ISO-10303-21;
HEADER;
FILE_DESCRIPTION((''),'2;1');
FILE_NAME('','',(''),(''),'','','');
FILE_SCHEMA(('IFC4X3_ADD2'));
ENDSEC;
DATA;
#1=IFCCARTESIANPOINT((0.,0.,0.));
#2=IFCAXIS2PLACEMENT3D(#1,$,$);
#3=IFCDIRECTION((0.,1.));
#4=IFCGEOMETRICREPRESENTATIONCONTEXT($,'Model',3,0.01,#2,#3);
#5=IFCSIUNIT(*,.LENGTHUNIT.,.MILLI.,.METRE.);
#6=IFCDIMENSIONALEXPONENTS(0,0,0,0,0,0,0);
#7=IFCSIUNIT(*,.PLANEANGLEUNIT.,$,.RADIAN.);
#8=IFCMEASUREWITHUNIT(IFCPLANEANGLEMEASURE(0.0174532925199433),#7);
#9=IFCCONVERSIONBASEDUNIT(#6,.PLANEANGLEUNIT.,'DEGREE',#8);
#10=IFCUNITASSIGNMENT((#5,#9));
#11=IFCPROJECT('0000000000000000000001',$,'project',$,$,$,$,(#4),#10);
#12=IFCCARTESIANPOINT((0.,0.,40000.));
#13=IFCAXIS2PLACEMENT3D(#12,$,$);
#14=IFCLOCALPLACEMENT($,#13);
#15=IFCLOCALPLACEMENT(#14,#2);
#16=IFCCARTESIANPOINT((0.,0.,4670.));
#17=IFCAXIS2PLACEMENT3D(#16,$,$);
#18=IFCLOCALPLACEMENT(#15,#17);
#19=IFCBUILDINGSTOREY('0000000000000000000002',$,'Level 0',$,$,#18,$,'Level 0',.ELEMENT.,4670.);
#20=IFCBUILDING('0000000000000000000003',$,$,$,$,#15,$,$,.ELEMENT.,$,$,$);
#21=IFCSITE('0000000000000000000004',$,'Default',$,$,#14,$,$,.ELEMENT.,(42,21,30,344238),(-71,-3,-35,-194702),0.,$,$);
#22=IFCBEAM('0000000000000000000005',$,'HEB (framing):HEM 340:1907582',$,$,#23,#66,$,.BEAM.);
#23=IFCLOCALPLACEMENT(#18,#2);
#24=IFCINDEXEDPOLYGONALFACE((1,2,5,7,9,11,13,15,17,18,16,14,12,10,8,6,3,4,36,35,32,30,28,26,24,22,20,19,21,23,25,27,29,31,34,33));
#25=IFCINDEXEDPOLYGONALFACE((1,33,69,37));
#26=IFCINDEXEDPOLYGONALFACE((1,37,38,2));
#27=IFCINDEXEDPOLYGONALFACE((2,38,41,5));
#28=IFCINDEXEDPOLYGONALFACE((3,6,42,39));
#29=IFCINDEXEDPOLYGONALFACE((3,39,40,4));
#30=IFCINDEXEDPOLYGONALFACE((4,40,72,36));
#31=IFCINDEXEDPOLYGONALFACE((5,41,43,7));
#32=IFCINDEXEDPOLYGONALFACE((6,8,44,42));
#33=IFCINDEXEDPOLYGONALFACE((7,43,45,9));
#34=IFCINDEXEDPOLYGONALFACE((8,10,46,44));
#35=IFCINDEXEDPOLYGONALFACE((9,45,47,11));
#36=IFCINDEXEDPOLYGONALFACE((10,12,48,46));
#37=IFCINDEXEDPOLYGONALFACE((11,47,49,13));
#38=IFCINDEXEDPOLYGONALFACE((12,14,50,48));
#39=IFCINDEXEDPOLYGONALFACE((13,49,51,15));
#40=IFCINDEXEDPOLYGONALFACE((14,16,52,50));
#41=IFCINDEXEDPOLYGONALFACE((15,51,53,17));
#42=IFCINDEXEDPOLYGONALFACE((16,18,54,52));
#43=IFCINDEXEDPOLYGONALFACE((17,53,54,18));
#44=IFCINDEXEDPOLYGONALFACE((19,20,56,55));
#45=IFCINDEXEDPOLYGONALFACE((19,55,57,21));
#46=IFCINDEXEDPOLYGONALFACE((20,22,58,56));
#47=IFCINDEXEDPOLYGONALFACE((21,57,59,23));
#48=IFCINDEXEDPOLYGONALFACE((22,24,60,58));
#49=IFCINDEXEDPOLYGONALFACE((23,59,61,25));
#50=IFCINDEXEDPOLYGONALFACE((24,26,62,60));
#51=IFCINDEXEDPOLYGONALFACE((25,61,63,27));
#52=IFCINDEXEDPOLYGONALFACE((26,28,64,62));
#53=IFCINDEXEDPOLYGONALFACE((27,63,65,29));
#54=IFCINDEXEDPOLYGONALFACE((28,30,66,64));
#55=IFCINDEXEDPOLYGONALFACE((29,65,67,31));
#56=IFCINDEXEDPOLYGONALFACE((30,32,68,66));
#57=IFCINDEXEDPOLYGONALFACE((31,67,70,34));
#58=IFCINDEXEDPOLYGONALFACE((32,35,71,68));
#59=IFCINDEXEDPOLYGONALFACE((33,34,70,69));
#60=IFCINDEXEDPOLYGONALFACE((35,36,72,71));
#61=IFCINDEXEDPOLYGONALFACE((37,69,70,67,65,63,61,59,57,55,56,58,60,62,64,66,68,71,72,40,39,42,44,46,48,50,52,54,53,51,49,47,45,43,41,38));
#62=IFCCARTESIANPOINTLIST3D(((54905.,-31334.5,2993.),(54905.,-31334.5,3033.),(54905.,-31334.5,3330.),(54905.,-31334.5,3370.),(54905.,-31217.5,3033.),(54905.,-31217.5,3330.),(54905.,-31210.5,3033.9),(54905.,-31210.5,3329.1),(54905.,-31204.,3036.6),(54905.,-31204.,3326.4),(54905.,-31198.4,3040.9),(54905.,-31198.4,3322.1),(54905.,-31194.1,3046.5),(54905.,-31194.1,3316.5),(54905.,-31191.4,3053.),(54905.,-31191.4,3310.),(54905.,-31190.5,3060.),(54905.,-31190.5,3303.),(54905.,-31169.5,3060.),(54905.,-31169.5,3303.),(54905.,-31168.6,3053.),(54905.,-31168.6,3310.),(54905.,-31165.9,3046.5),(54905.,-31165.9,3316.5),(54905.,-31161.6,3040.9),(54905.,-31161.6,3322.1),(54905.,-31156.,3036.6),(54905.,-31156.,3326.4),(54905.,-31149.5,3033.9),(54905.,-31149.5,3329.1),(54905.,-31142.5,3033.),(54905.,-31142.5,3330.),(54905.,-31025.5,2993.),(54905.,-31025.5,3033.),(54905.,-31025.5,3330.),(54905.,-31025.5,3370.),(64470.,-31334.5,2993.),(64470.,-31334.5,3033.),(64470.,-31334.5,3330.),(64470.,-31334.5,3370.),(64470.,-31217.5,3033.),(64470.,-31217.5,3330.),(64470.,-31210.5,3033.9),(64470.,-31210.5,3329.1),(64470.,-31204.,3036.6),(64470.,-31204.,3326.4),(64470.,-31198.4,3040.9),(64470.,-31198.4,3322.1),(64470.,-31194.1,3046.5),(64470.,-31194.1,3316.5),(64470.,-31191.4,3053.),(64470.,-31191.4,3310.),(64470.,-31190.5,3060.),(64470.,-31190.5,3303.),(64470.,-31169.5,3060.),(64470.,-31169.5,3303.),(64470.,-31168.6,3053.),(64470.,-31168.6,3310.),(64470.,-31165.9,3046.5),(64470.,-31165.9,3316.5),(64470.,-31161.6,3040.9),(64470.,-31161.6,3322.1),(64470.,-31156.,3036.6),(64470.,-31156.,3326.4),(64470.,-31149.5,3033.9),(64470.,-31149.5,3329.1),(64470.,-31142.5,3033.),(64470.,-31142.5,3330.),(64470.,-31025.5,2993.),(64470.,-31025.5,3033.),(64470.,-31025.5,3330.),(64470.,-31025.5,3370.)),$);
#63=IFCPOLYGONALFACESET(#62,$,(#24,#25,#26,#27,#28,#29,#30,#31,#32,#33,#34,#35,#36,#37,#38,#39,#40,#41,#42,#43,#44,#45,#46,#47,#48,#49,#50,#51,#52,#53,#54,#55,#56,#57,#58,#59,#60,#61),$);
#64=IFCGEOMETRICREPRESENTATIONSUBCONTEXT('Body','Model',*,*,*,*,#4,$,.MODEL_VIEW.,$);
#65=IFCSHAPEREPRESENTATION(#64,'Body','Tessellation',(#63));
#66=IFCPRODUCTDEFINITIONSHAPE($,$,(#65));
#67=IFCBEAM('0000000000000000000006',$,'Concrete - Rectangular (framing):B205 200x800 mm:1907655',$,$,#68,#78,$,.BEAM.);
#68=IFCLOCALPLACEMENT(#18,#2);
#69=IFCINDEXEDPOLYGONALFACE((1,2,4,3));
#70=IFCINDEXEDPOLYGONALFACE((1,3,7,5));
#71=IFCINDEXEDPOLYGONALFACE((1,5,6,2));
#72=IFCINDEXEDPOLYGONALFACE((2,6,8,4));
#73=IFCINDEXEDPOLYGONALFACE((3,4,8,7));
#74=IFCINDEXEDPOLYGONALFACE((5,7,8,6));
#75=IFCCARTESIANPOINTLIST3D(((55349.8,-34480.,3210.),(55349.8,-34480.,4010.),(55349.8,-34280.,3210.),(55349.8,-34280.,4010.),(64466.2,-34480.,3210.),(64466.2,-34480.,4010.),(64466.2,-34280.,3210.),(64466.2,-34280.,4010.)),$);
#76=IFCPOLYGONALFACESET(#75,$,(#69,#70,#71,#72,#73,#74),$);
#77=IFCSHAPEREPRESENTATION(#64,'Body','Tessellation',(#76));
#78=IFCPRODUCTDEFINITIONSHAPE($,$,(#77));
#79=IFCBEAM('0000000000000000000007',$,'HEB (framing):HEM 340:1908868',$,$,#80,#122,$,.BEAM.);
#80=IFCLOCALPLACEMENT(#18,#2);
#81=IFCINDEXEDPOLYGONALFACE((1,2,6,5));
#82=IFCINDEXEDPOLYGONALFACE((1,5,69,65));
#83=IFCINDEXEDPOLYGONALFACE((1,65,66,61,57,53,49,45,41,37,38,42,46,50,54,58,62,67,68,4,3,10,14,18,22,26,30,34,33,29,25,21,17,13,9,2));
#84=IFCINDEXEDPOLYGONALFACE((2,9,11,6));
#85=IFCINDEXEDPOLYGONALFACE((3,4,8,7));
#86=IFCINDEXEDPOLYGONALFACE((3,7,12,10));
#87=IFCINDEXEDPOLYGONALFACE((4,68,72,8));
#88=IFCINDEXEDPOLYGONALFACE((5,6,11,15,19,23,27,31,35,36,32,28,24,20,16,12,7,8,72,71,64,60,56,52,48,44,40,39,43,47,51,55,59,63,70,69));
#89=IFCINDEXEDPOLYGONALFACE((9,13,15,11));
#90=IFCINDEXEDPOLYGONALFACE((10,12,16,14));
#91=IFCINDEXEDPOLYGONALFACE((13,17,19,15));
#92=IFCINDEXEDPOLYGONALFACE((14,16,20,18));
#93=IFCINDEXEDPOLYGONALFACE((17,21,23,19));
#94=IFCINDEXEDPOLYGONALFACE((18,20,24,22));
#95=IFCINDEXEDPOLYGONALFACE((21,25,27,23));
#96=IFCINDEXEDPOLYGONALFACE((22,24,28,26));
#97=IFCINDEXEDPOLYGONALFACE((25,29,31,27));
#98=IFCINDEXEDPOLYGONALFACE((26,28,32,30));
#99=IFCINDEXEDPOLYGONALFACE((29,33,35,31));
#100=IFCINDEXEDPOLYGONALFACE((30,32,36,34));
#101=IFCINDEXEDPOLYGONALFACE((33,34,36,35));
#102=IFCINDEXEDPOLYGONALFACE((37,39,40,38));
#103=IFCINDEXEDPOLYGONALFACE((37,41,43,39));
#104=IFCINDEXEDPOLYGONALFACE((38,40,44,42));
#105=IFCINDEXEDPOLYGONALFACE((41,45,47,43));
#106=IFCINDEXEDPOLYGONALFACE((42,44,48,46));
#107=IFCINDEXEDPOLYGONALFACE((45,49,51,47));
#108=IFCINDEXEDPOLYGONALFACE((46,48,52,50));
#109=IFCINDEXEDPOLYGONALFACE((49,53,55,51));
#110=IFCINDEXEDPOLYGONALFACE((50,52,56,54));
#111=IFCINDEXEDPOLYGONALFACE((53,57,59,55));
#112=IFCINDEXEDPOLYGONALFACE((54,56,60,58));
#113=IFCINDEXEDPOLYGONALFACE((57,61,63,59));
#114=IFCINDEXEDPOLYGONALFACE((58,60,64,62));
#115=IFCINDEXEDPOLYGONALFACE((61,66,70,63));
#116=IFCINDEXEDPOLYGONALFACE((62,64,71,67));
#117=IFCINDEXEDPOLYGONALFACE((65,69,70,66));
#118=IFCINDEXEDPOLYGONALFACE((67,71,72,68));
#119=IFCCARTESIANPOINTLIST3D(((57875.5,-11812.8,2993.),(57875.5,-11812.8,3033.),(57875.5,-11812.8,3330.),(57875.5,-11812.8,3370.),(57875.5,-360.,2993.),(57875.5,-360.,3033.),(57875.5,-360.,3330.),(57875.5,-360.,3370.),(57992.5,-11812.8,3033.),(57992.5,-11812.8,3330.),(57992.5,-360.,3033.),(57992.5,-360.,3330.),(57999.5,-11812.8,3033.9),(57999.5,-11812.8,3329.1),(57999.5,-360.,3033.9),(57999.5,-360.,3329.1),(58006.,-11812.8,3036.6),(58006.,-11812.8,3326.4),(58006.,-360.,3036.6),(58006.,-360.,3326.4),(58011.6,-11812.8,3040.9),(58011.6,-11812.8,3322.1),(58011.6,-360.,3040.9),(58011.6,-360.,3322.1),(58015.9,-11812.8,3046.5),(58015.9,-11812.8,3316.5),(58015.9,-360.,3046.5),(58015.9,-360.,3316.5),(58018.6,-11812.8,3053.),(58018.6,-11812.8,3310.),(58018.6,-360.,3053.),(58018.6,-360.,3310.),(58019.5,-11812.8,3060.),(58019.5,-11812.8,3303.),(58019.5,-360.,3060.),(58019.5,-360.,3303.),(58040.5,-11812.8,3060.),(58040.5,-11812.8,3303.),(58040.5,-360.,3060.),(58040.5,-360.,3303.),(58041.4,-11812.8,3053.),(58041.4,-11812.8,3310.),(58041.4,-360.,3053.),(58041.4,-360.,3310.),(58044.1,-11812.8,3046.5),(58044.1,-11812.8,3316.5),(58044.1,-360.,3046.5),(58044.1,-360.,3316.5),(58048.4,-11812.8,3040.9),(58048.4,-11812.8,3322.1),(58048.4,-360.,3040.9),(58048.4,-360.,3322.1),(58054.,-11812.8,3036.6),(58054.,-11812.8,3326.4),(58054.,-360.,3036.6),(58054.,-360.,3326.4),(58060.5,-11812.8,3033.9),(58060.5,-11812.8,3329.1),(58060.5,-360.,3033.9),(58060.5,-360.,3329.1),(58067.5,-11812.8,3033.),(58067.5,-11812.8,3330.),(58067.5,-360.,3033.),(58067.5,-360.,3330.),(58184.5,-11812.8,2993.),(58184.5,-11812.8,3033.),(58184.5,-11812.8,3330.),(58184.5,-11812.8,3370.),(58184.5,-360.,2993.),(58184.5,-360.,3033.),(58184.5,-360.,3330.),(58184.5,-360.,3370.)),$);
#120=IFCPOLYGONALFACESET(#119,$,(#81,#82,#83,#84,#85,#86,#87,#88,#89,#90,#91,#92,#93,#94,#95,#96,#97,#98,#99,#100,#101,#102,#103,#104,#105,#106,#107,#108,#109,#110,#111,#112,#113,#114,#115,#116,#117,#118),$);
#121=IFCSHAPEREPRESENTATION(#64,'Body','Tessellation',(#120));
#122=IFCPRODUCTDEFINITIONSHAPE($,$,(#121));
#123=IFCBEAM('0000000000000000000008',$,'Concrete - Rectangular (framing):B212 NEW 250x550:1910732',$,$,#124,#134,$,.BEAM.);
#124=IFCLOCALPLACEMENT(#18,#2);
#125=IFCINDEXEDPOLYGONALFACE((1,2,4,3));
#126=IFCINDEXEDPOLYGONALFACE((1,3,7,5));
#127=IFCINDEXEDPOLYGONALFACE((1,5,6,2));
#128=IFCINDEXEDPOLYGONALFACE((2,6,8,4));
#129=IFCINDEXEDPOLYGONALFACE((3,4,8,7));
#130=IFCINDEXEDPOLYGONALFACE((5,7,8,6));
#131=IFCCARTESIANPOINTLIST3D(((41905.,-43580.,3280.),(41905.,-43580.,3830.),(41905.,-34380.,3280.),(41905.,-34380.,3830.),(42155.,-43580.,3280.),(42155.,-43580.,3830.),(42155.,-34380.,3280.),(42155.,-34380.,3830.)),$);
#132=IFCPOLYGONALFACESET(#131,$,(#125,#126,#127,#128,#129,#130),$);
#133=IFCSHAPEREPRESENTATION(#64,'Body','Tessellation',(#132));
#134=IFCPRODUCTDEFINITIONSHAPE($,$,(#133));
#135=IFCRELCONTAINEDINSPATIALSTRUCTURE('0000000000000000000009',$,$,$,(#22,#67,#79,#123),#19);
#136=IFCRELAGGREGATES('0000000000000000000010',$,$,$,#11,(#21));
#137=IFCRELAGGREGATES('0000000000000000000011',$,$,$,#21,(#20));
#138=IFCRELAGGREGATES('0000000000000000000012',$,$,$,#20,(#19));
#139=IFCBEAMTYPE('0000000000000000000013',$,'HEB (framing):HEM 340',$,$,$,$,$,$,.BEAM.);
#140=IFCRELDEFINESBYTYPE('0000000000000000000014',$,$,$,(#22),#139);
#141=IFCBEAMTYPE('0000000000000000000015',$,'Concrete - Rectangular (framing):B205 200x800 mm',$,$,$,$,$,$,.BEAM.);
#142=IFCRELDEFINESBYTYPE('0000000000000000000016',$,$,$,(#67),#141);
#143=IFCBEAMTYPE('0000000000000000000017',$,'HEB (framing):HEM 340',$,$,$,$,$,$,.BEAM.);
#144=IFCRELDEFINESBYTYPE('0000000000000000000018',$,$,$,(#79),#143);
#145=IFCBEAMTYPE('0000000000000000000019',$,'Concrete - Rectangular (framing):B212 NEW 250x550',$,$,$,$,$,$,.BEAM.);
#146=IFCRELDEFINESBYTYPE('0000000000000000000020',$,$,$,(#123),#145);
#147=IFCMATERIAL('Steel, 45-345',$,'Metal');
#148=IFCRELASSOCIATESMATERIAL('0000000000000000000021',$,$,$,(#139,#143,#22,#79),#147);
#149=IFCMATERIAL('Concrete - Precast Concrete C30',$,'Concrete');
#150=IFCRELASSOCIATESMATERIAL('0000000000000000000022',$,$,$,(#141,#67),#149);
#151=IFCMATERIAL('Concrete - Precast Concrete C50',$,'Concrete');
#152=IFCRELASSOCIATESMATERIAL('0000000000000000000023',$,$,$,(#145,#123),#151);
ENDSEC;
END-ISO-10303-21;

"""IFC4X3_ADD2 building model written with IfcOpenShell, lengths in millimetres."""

from ifc_helpers import new_model, entity, si_unit, converted_unit, direction, frame, frame_2d, origin, origin_2d_with_axis, place, context, subcontext, project, spatial, polyline, circle_curve, parameter, trimmed, segment, composite_curve, rectangle, outline, extrude, source, transform, mapped, material, material_profile, profile_set, profile_usage, type_object, type_shapes, element, save


model = new_model("IFC4X3_ADD2")

# Units and contexts
model_context = context("Model", 3, precision=0.01, world=origin(), true_north=direction((0.0, 1.0)))
body_context = subcontext(model_context, "Body", "Model", "MODEL_VIEW")
ifc_project = project(units=[si_unit("LENGTHUNIT", "METRE", prefix="MILLI"), converted_unit("PLANEANGLEUNIT", "DEGREE", entity("IfcPlaneAngleMeasure", 0.0174532925199433), si_unit("PLANEANGLEUNIT", "RADIAN"), dimensions=[0, 0, 0, 0, 0, 0, 0])], contexts=[model_context])

# Site, building, storey
site_placement = place(None, frame((0.0, 0.0, 40000.0)))
site = spatial("IfcSite", under=ifc_project, at=site_placement, Name="Default", CompositionType="ELEMENT", RefLatitude=(42, 21, 30, 344238), RefLongitude=(-71, -3, -35, -194702), RefElevation=0.0)
building_placement = place(site_placement, origin())
building = spatial("IfcBuilding", under=site, at=building_placement, CompositionType="ELEMENT")
storey_placement = place(building_placement, frame((0.0, 0.0, 4670.0)))
storey = spatial("IfcBuildingStorey", under=building, at=storey_placement, Name="Level 0", LongName="Level 0", CompositionType="ELEMENT", Elevation=4670.0)

# Shared definitions
ifc_material_1 = material(Name="Steel, 45-345", Category="Metal")

# Beams
ifc_material_profile_1 = material_profile(ifc_material_1, outline(composite_curve([segment(polyline([(-154.5, -148.5), (-154.5, -188.5)]), True, "CONTINUOUS"), segment(polyline([(-154.5, -188.5), (154.5, -188.5)]), True, "CONTINUOUS"), segment(polyline([(154.5, -188.5), (154.5, -148.5)]), True, "CONTINUOUS"), segment(polyline([(154.5, -148.5), (37.5, -148.5)]), True, "CONTINUOUS"), segment(trimmed(circle_curve(frame_2d((37.5, -121.5), x_axis=(1.0, 0.0)), 27.0), [parameter(180.0)], [parameter(270.0)], True, "PARAMETER"), False, "CONTINUOUS"), segment(polyline([(10.5, -121.5), (10.5, 121.5)]), True, "CONTINUOUS"), segment(trimmed(circle_curve(frame_2d((37.5, 121.5), x_axis=(1.0, 0.0)), 27.0), [parameter(90.0)], [parameter(180.0)], True, "PARAMETER"), False, "CONTINUOUS"), segment(polyline([(37.5, 148.5), (154.5, 148.5)]), True, "CONTINUOUS"), segment(polyline([(154.5, 148.5), (154.5, 188.5)]), True, "CONTINUOUS"), segment(polyline([(154.5, 188.5), (-154.5, 188.5)]), True, "CONTINUOUS"), segment(polyline([(-154.5, 188.5), (-154.5, 148.5)]), True, "CONTINUOUS"), segment(polyline([(-154.5, 148.5), (-37.5, 148.5)]), True, "CONTINUOUS"), segment(trimmed(circle_curve(frame_2d((-37.5, 121.5), x_axis=(1.0, 0.0)), 27.0), [parameter(360.0)], [parameter(90.0)], True, "PARAMETER"), False, "CONTINUOUS"), segment(polyline([(-10.5, 121.5), (-10.5, -121.5)]), True, "CONTINUOUS"), segment(trimmed(circle_curve(frame_2d((-37.5, -121.5), x_axis=(1.0, 0.0)), 27.0), [parameter(270.0)], [parameter(0.0)], True, "PARAMETER"), False, "CONTINUOUS"), segment(polyline([(-37.5, -148.5), (-154.5, -148.5)]), True, "CONTINUOUS")], self_intersect=False)), Name="HEM 340")
ifc_profile_set_1 = profile_set([ifc_material_profile_1], Name="HEM 340")
ifc_profile_usage_1 = profile_usage(ifc_profile_set_1, cardinal=8)
beam_type_1 = type_object("IfcBeamType", Name="HEB (framing):HEM 340", PredefinedType="BEAM", material=ifc_profile_set_1)
shared_shape_1 = source(origin(), body_context, "Body", "SweptSolid", [
    extrude(outline(composite_curve([segment(polyline([(-154.5, -148.5), (-154.5, -188.5)]), True, "CONTINUOUS"), segment(polyline([(-154.5, -188.5), (154.5, -188.5)]), True, "CONTINUOUS"), segment(polyline([(154.5, -188.5), (154.5, -148.5)]), True, "CONTINUOUS"), segment(polyline([(154.5, -148.5), (37.5, -148.5)]), True, "CONTINUOUS"), segment(trimmed(circle_curve(frame_2d((37.5, -121.5), x_axis=(1.0, 0.0)), 27.0), [parameter(180.0)], [parameter(270.0)], True, "PARAMETER"), False, "CONTINUOUS"), segment(polyline([(10.5, -121.5), (10.5, 121.5)]), True, "CONTINUOUS"), segment(trimmed(circle_curve(frame_2d((37.5, 121.5), x_axis=(1.0, 0.0)), 27.0), [parameter(90.0)], [parameter(180.0)], True, "PARAMETER"), False, "CONTINUOUS"), segment(polyline([(37.5, 148.5), (154.5, 148.5)]), True, "CONTINUOUS"), segment(polyline([(154.5, 148.5), (154.5, 188.5)]), True, "CONTINUOUS"), segment(polyline([(154.5, 188.5), (-154.5, 188.5)]), True, "CONTINUOUS"), segment(polyline([(-154.5, 188.5), (-154.5, 148.5)]), True, "CONTINUOUS"), segment(polyline([(-154.5, 148.5), (-37.5, 148.5)]), True, "CONTINUOUS"), segment(trimmed(circle_curve(frame_2d((-37.5, 121.5), x_axis=(1.0, 0.0)), 27.0), [parameter(360.0)], [parameter(90.0)], True, "PARAMETER"), False, "CONTINUOUS"), segment(polyline([(-10.5, 121.5), (-10.5, -121.5)]), True, "CONTINUOUS"), segment(trimmed(circle_curve(frame_2d((-37.5, -121.5), x_axis=(1.0, 0.0)), 27.0), [parameter(270.0)], [parameter(0.0)], True, "PARAMETER"), False, "CONTINUOUS"), segment(polyline([(-37.5, -148.5), (-154.5, -148.5)]), True, "CONTINUOUS")], self_intersect=False)), frame((-4680.0, 0.0, 0.0), z_axis=(-1.0, 0.0, 0.0), x_axis=(0.0, -1.0, 0.0)), (0.0, 0.0, -1.0), 9565.0),
])
type_shapes(beam_type_1, [shared_shape_1])
beam_1_placement = place(storey_placement, frame((59585.0, -31180.0, 3181.5)))
element("IfcBeam", 1, at=beam_1_placement, inside=storey, type_object=beam_type_1, material=ifc_profile_usage_1, Name="HEB (framing):HEM 340:1907582", PredefinedType="BEAM", context=body_context, shape_type="MappedRepresentation", body=[
    mapped(shared_shape_1, transform((0.0, 0.0, 0.0), scale=1.0)),
])
ifc_material_2 = material(Name="Concrete - Precast Concrete C30", Category="Concrete")
ifc_material_profile_2 = material_profile(ifc_material_2, rectangle(XDim=9116.4, YDim=200.0, at=origin_2d_with_axis()), Name="B205 200x800 mm")
ifc_profile_set_2 = profile_set([ifc_material_profile_2], Name="B205 200x800 mm")
ifc_profile_usage_2 = profile_usage(ifc_profile_set_2, cardinal=8)
beam_type_2 = type_object("IfcBeamType", Name="Concrete - Rectangular (framing):B205 200x800 mm", PredefinedType="BEAM", material=ifc_profile_set_2)
shared_shape_2 = source(origin(), body_context, "Body", "SweptSolid", [
    extrude(rectangle(XDim=9116.4, YDim=200.0, at=origin_2d_with_axis()), frame((453.0, 0.0, -400.0), z_axis=(0.0, 0.0, 1.0), x_axis=(-1.0, 0.0, 0.0)), (0.0, 0.0, 1.0), 800.0),
])
type_shapes(beam_type_2, [shared_shape_2])
beam_2_placement = place(storey_placement, frame((59455.0, -34380.0, 3610.0)))
element("IfcBeam", 2, at=beam_2_placement, inside=storey, type_object=beam_type_2, material=ifc_profile_usage_2, Name="Concrete - Rectangular (framing):B205 200x800 mm:1907655", PredefinedType="BEAM", context=body_context, shape_type="MappedRepresentation", body=[
    mapped(shared_shape_2, transform((0.0, 0.0, 0.0), scale=1.0)),
])
beam_type_3 = type_object("IfcBeamType", Name="HEB (framing):HEM 340", PredefinedType="BEAM", material=ifc_profile_set_1)
shared_shape_3 = source(origin(), body_context, "Body", "SweptSolid", [
    extrude(outline(composite_curve([segment(polyline([(-154.5, -148.5), (-154.5, -188.5)]), True, "CONTINUOUS"), segment(polyline([(-154.5, -188.5), (154.5, -188.5)]), True, "CONTINUOUS"), segment(polyline([(154.5, -188.5), (154.5, -148.5)]), True, "CONTINUOUS"), segment(polyline([(154.5, -148.5), (37.5, -148.5)]), True, "CONTINUOUS"), segment(trimmed(circle_curve(frame_2d((37.5, -121.5), x_axis=(1.0, 0.0)), 27.0), [parameter(180.0)], [parameter(270.0)], True, "PARAMETER"), False, "CONTINUOUS"), segment(polyline([(10.5, -121.5), (10.5, 121.5)]), True, "CONTINUOUS"), segment(trimmed(circle_curve(frame_2d((37.5, 121.5), x_axis=(1.0, 0.0)), 27.0), [parameter(90.0)], [parameter(180.0)], True, "PARAMETER"), False, "CONTINUOUS"), segment(polyline([(37.5, 148.5), (154.5, 148.5)]), True, "CONTINUOUS"), segment(polyline([(154.5, 148.5), (154.5, 188.5)]), True, "CONTINUOUS"), segment(polyline([(154.5, 188.5), (-154.5, 188.5)]), True, "CONTINUOUS"), segment(polyline([(-154.5, 188.5), (-154.5, 148.5)]), True, "CONTINUOUS"), segment(polyline([(-154.5, 148.5), (-37.5, 148.5)]), True, "CONTINUOUS"), segment(trimmed(circle_curve(frame_2d((-37.5, 121.5), x_axis=(1.0, 0.0)), 27.0), [parameter(360.0)], [parameter(90.0)], True, "PARAMETER"), False, "CONTINUOUS"), segment(polyline([(-10.5, 121.5), (-10.5, -121.5)]), True, "CONTINUOUS"), segment(trimmed(circle_curve(frame_2d((-37.5, -121.5), x_axis=(1.0, 0.0)), 27.0), [parameter(270.0)], [parameter(0.0)], True, "PARAMETER"), False, "CONTINUOUS"), segment(polyline([(-37.5, -148.5), (-154.5, -148.5)]), True, "CONTINUOUS")], self_intersect=False)), frame((-5860.0, 0.0, 0.0), z_axis=(-1.0, 0.0, 0.0), x_axis=(0.0, -1.0, 0.0)), (0.0, 0.0, -1.0), 11452.8),
])
type_shapes(beam_type_3, [shared_shape_3])
beam_3_placement = place(storey_placement, frame((58030.0, -6220.0, 3181.5), z_axis=(0.0, 0.0, 1.0), x_axis=(0.0, -1.0, 0.0)))
element("IfcBeam", 3, at=beam_3_placement, inside=storey, type_object=beam_type_3, material=ifc_profile_usage_1, Name="HEB (framing):HEM 340:1908868", PredefinedType="BEAM", context=body_context, shape_type="MappedRepresentation", body=[
    mapped(shared_shape_3, transform((0.0, 0.0, 0.0), scale=1.0)),
])
ifc_material_3 = material(Name="Concrete - Precast Concrete C50", Category="Concrete")
ifc_material_profile_3 = material_profile(ifc_material_3, rectangle(XDim=9200.0, YDim=250.0, at=origin_2d_with_axis()), Name="B212 NEW 250x550")
ifc_profile_set_3 = profile_set([ifc_material_profile_3], Name="B212 NEW 250x550")
ifc_profile_usage_3 = profile_usage(ifc_profile_set_3, cardinal=8)
beam_type_4 = type_object("IfcBeamType", Name="Concrete - Rectangular (framing):B212 NEW 250x550", PredefinedType="BEAM", material=ifc_profile_set_3)
shared_shape_4 = source(origin(), body_context, "Body", "SweptSolid", [
    extrude(rectangle(XDim=9200.0, YDim=250.0, at=origin_2d_with_axis()), frame((0.0, 0.0, -275.0), z_axis=(0.0, 0.0, 1.0), x_axis=(-1.0, 0.0, 0.0)), (0.0, 0.0, 1.0), 550.0),
])
type_shapes(beam_type_4, [shared_shape_4])
for number, where, z_axis, x_axis, name in (
    (4, (42030.0, -38980.0, 3555.0), (0.0, 0.0, 1.0), (0.0, 1.0, 0.0), "Concrete - Rectangular (framing):B212 NEW 250x550:1910732"),
):
    element("IfcBeam", number, at=place(storey_placement, frame(where, z_axis=z_axis, x_axis=x_axis)), inside=storey, type_object=beam_type_4, material=ifc_profile_usage_3, Name=name, PredefinedType="BEAM", context=body_context, shape_type="MappedRepresentation", body=[
        mapped(shared_shape_4, transform((0.0, 0.0, 0.0), scale=1.0)),
    ])

save(model, "model.ifc")
